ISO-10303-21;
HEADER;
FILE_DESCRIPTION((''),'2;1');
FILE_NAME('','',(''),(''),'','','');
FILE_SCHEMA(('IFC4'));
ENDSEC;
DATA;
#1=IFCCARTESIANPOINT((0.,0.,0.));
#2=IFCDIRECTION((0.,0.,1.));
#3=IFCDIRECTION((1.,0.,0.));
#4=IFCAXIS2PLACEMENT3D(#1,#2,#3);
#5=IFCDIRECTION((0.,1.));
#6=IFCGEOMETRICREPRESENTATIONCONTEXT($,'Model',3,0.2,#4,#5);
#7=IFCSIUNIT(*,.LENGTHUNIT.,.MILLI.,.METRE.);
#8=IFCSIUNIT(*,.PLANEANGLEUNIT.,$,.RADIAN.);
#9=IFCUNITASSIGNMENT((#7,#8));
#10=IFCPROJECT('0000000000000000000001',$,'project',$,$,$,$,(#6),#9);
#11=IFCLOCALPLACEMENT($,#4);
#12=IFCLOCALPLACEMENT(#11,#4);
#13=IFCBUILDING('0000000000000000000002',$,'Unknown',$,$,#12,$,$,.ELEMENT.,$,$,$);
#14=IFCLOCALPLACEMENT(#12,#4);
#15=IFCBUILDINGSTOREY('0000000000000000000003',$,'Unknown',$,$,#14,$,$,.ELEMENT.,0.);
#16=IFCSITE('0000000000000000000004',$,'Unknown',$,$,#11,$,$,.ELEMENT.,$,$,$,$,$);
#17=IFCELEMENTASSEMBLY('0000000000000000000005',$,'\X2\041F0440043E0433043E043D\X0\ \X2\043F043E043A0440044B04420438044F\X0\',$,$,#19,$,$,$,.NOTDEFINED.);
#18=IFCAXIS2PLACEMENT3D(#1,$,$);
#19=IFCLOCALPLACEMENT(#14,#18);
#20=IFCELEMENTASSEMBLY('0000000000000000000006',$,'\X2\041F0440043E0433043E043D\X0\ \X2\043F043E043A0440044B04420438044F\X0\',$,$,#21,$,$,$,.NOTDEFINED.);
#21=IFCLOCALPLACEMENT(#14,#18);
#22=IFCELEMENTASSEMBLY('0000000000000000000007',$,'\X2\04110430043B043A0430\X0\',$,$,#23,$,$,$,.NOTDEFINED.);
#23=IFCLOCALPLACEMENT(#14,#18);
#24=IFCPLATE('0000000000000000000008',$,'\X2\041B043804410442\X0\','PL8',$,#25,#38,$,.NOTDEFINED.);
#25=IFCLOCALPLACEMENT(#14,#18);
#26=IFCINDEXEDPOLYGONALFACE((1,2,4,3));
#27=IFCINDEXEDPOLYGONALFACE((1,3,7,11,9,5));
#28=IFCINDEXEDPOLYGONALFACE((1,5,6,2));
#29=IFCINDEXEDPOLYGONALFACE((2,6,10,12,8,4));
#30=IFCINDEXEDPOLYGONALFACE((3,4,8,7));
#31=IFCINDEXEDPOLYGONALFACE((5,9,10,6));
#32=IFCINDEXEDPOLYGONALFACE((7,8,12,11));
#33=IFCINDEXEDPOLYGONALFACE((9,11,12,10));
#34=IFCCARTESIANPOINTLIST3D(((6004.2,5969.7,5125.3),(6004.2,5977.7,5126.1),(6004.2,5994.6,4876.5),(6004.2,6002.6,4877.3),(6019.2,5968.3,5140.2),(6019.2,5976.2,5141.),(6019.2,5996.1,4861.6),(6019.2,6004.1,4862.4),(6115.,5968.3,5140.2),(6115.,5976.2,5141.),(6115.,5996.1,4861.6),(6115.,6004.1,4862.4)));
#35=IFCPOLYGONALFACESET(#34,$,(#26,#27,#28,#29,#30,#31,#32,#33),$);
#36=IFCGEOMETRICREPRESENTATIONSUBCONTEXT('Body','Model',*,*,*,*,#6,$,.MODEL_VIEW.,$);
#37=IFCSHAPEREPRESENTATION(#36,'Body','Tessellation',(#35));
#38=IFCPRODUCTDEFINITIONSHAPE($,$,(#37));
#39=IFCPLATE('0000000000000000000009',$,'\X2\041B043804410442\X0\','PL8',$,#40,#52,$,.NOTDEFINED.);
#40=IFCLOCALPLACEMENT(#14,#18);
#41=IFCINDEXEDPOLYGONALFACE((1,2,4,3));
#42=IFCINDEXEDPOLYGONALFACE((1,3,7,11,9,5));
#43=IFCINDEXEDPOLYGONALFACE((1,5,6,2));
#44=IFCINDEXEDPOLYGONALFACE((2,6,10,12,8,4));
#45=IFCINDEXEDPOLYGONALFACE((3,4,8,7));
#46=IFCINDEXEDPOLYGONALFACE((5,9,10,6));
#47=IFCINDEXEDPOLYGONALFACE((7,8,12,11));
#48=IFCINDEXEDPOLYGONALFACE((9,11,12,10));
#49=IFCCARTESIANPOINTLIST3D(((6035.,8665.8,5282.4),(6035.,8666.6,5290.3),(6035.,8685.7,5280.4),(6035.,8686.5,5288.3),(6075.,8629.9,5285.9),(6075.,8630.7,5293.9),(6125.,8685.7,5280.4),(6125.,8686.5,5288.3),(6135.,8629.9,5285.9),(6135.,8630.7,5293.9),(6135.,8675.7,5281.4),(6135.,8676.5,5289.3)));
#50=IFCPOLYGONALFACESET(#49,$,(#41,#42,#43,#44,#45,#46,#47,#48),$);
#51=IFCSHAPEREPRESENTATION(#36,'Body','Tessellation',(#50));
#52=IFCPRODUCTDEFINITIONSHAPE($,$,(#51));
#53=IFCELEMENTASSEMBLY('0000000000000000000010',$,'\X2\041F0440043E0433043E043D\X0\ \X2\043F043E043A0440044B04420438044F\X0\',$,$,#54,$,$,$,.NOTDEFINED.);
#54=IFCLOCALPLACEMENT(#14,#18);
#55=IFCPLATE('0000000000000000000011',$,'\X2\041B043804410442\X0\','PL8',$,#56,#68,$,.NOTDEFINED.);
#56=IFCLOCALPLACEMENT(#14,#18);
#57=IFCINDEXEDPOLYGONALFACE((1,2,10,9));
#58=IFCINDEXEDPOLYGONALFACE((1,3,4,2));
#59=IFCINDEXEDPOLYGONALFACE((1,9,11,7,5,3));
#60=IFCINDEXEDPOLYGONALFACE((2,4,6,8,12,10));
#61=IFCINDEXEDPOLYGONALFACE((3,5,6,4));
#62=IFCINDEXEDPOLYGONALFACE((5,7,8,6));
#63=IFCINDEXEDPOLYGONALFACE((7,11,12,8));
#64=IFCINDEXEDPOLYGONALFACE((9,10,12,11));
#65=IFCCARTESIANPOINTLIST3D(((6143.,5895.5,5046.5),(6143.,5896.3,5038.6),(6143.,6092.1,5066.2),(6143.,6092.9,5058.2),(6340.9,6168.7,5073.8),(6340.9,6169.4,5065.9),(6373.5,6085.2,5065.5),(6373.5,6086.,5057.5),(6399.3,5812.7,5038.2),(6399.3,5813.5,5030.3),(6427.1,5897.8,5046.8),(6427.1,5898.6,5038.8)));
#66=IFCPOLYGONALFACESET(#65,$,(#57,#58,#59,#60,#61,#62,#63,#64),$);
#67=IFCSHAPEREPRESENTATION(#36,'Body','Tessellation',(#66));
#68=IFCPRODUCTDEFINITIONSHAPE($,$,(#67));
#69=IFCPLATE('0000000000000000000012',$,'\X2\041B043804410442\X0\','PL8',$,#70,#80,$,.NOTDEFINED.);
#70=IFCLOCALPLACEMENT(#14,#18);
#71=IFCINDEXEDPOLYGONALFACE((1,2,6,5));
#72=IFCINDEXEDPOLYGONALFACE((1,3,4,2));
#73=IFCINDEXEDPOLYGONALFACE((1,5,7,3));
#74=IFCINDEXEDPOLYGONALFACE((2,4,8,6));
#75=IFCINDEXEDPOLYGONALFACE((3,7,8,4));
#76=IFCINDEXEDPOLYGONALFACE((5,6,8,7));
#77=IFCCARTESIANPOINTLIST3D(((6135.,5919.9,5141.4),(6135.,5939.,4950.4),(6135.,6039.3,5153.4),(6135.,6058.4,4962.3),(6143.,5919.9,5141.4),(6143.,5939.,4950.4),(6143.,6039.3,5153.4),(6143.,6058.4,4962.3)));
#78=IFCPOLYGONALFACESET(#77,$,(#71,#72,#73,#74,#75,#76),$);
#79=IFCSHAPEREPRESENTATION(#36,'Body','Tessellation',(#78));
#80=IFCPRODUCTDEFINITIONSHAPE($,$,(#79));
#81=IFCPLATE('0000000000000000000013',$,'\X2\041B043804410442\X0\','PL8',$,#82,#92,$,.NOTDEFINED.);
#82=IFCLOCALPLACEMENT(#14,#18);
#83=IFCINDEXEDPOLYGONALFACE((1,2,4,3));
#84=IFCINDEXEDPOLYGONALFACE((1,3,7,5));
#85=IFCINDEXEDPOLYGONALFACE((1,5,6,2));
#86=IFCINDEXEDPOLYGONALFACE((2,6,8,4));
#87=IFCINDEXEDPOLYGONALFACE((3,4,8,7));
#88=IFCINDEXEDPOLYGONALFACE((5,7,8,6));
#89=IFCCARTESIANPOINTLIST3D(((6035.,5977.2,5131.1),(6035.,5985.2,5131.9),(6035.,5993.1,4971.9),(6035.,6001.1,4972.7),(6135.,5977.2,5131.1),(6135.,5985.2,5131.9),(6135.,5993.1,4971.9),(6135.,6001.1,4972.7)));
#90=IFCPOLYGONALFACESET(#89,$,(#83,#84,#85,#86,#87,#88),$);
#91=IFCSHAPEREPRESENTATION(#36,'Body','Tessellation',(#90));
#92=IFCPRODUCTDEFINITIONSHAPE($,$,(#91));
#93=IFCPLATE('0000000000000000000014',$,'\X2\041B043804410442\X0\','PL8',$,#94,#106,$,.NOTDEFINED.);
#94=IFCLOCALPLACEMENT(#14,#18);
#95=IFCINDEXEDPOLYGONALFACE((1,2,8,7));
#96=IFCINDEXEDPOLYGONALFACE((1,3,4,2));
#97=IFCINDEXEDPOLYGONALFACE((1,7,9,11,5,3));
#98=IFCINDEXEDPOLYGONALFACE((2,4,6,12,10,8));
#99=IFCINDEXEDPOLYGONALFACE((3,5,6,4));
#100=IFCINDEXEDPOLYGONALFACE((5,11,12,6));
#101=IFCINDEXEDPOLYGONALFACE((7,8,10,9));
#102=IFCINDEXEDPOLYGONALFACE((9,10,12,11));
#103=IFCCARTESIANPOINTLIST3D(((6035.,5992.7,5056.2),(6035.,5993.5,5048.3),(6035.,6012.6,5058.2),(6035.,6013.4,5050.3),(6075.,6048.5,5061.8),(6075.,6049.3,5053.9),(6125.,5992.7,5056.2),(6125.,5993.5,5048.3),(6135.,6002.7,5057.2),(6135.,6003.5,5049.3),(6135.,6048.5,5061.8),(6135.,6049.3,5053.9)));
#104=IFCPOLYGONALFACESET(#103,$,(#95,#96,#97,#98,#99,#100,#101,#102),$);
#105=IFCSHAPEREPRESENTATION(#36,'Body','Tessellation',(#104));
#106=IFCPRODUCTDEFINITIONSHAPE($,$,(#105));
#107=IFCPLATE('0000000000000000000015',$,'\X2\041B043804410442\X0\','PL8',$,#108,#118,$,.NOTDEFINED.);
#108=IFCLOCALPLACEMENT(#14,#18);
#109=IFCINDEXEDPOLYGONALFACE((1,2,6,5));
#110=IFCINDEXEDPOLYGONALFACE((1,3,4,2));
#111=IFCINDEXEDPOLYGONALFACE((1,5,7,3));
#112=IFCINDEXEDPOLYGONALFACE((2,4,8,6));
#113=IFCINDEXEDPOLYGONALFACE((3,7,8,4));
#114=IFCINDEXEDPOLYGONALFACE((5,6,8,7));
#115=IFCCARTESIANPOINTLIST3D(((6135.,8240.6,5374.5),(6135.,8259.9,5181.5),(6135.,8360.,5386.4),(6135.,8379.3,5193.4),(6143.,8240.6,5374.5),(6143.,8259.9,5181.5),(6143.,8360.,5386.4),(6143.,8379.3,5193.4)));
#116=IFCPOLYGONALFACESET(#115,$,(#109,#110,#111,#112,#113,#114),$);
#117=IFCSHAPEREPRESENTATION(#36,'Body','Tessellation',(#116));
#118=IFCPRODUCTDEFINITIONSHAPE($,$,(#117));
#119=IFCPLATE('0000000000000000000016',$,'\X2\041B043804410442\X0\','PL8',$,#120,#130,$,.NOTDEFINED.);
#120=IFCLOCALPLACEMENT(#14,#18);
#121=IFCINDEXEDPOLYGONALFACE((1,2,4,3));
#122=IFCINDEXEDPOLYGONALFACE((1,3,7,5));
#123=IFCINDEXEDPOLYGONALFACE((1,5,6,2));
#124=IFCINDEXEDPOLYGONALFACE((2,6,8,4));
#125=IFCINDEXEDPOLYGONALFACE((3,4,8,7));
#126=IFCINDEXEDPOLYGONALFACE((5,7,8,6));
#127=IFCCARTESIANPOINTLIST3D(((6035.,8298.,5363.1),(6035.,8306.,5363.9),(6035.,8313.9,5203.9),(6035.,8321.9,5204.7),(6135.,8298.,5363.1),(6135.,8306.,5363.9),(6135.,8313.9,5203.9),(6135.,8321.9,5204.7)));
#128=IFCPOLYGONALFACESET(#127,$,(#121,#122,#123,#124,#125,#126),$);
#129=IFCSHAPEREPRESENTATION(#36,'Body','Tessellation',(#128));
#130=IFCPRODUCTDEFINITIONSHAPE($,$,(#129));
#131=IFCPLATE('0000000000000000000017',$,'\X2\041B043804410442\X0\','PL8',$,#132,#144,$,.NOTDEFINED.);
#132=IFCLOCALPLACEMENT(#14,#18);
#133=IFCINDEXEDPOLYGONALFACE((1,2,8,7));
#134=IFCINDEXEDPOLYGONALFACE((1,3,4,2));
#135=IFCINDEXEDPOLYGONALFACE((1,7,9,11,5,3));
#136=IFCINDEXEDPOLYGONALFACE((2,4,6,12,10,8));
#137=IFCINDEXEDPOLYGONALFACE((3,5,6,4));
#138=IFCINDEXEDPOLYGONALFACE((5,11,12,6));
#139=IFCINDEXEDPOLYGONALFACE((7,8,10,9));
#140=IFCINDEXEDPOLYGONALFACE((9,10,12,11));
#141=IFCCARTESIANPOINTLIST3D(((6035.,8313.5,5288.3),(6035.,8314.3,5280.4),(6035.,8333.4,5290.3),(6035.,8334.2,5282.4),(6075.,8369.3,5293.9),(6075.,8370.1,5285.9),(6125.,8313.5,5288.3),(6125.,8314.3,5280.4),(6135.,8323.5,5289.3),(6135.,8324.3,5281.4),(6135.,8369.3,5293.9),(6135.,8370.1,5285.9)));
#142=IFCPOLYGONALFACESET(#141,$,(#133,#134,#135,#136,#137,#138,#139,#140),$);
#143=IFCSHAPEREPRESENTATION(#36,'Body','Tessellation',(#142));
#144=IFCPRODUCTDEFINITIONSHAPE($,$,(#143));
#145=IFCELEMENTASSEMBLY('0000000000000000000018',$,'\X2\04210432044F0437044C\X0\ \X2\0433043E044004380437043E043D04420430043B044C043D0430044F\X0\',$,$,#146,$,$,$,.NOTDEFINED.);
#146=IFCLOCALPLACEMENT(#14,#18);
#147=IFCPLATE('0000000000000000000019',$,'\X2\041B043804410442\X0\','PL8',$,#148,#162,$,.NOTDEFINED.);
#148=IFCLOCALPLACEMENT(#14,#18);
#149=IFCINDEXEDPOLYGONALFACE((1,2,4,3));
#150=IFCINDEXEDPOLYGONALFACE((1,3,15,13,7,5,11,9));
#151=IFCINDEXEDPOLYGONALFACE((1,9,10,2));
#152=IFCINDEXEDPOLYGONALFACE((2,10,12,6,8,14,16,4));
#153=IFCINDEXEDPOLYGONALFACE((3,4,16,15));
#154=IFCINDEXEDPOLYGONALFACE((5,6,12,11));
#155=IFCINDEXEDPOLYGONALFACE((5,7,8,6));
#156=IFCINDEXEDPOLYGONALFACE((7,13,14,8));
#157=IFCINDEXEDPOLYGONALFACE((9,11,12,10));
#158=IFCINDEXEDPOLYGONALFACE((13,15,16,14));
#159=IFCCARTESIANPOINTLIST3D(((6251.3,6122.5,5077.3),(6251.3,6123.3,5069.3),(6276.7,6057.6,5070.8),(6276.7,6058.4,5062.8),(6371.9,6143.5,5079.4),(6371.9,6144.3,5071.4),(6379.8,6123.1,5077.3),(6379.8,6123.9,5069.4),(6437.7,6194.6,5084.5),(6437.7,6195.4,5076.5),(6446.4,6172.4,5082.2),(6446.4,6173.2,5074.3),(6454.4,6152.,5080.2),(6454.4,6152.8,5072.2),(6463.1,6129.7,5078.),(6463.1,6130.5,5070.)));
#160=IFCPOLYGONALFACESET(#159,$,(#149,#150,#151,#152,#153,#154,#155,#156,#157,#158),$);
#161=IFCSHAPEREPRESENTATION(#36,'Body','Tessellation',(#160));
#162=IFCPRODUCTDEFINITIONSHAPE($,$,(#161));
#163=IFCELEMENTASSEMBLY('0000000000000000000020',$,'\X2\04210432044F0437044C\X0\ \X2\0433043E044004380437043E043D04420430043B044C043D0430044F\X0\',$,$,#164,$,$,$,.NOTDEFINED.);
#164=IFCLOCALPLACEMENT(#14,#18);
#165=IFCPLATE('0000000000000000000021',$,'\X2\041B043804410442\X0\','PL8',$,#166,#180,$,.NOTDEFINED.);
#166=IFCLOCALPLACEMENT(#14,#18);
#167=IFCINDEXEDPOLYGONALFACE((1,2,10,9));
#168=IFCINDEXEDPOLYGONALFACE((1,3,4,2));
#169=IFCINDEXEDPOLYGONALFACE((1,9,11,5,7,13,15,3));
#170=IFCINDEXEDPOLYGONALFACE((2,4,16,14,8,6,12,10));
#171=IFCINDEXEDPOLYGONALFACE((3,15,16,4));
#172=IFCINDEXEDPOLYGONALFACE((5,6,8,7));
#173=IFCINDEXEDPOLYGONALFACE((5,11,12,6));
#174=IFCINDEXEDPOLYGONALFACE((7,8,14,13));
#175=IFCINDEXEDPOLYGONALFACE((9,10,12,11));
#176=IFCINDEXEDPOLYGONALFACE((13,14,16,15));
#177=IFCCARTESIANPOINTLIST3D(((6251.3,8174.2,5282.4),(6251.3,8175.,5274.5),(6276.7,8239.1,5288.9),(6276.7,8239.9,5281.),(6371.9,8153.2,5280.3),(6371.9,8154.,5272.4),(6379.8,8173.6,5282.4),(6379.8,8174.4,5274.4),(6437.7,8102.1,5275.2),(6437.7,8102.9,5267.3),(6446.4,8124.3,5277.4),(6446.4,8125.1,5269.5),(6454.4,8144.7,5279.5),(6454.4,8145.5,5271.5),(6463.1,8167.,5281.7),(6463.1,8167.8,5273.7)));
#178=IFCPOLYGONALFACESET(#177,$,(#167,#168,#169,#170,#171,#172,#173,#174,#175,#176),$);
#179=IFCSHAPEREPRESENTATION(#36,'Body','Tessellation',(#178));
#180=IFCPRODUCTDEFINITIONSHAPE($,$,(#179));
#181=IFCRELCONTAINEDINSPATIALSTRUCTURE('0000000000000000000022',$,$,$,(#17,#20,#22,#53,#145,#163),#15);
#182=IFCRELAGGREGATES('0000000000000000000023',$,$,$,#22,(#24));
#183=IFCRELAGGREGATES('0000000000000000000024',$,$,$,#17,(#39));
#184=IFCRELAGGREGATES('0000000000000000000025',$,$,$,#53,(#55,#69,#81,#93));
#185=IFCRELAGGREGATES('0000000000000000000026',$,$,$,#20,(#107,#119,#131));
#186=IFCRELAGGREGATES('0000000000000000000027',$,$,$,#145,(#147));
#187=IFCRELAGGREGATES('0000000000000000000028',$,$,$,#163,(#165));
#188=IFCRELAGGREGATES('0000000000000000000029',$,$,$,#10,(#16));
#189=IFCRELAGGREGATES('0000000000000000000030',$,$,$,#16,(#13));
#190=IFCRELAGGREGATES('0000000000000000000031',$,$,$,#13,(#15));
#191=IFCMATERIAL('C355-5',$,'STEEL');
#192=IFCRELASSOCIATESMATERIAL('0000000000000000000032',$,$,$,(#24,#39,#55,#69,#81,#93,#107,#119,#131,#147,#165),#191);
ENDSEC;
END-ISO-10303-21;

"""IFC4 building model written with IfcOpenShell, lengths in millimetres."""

from ifc_helpers import new_model, si_unit, direction, frame, origin_with_axes, place, context, subcontext, project, spatial, line, indexed_curve, outline, extrude, material, element, aggregate, save


model = new_model("IFC4")

# Units and contexts
model_context = context("Model", 3, precision=0.2, world=origin_with_axes(), true_north=direction((0.0, 1.0)))
body_context = subcontext(model_context, "Body", "Model", "MODEL_VIEW")
ifc_project = project(units=[si_unit("LENGTHUNIT", "METRE", prefix="MILLI"), si_unit("PLANEANGLEUNIT", "RADIAN")], contexts=[model_context])

# Site, building, storey
site_placement = place(None, origin_with_axes())
site = spatial("IfcSite", under=ifc_project, at=site_placement, Name="Unknown", CompositionType="ELEMENT")
building_placement = place(site_placement, origin_with_axes())
building = spatial("IfcBuilding", under=site, at=building_placement, Name="Unknown", CompositionType="ELEMENT")
storey_placement = place(building_placement, origin_with_axes())
storey = spatial("IfcBuildingStorey", under=building, at=storey_placement, Name="Unknown", CompositionType="ELEMENT", Elevation=0.0)

# Element assemblies
assembly_1_placement = place(storey_placement, frame((12000.0, 8690.0, 5283.9), z_axis=(0.0, -0.995037, 0.099504), x_axis=(-1.0, 0.0, 0.0)))
assembly_1 = element("IfcElementAssembly", 1, at=assembly_1_placement, inside=storey, Name="Прогон покрытия", PredefinedType="NOTDEFINED")
ifc_material_1 = material(Name="C355-5", Category="STEEL")
assembly_2_placement = place(storey_placement, frame((6000.0, 8310.0, 5283.9), z_axis=(0.0, 0.995037, 0.099504), x_axis=(1.0, 0.0, 0.0)))
assembly_2 = element("IfcElementAssembly", 2, at=assembly_2_placement, inside=storey, Name="Прогон покрытия", PredefinedType="NOTDEFINED")

# Element assembly, plate
assembly_3_placement = place(storey_placement, frame((6000.0, 346.0, 4437.3), z_axis=(1.0, 0.0, 0.0), x_axis=(0.0, 0.995037, 0.099504)))
assembly_3 = element("IfcElementAssembly", 3, at=assembly_3_placement, inside=storey, Name="Балка", PredefinedType="NOTDEFINED")
plate_1_placement = place(assembly_3_placement, frame((5668.3, 140.0, 115.0), z_axis=(-1.0, 0.0, 0.0), x_axis=(0.0, 0.0, -1.0)))
plate_1 = element("IfcPlate", 4, at=plate_1_placement, material=ifc_material_1, Name="Лист", Description="PL8", PredefinedType="NOTDEFINED", context=body_context, shape_type="SolidModel", body=[
    extrude(outline(indexed_curve([(0.0, 0.0), (95.8, 0.0), (110.8, 15.0), (110.8, 265.0), (95.8, 280.0), (0.0, 280.0)], segments=[line(1, 2, 3, 4, 5, 6, 1)])), frame((0.0, 0.0, 4.0), z_axis=(0.0, 0.0, 1.0), x_axis=(1.0, 0.0, 0.0)), (0.0, 0.0, -1.0), 8.0),
])
aggregate(assembly_3, [plate_1])

# Plate
plate_2_placement = place(assembly_1_placement, frame((5965.0, 0.0, 60.0), z_axis=(0.0, 1.0, 0.0), x_axis=(0.0, 0.0, -1.0)))
plate_2 = element("IfcPlate", 5, at=plate_2_placement, material=ifc_material_1, Name="Лист", Description="PL8", PredefinedType="NOTDEFINED", context=body_context, shape_type="SolidModel", body=[
    extrude(outline(indexed_curve([(0.0, 40.0), (36.0, 0.0), (56.0, 0.0), (56.0, 90.0), (46.0, 100.0), (0.0, 100.0)], segments=[line(1, 2, 3, 4, 5, 6, 1)])), frame((0.0, 0.0, 4.0), z_axis=(0.0, 0.0, 1.0), x_axis=(1.0, 0.0, 0.0)), (0.0, 0.0, -1.0), 8.0),
])
aggregate(assembly_1, [plate_2])

# Element assembly, plates
assembly_4_placement = place(storey_placement, frame((6000.0, 5989.2, 5051.9), z_axis=(0.0, 0.995037, 0.099504), x_axis=(1.0, 0.0, 0.0)))
assembly_4 = element("IfcElementAssembly", 6, at=assembly_4_placement, inside=storey, Name="Прогон покрытия", PredefinedType="NOTDEFINED")
plate_3_placement = place(assembly_4_placement, frame((373.5, 0.0, 96.9), z_axis=(0.0, -1.0, 0.0), x_axis=(-0.362317, 0.0, 0.932055)))
plate_3 = element("IfcPlate", 7, at=plate_3_placement, material=ifc_material_1, Name="Лист", Description="PL8", PredefinedType="NOTDEFINED", context=body_context, shape_type="SolidModel", body=[
    extrude(outline(indexed_curve([(0.0, 0.0), (90.0, 0.0), (90.0, 212.3), (-94.2, 283.9), (-264.6, 75.2), (-194.9, 18.3)], segments=[line(1, 2, 3, 4, 5, 6, 1)])), frame((0.0, 0.0, 4.0), z_axis=(0.0, 0.0, 1.0), x_axis=(1.0, 0.0, 0.0)), (0.0, 0.0, -1.0), 8.0),
])
plate_4_placement = place(assembly_4_placement, frame((139.0, -96.0, -60.0), z_axis=(-1.0, 0.0, 0.0), x_axis=(0.0, 0.0, 1.0)))
plate_4 = element("IfcPlate", 8, at=plate_4_placement, material=ifc_material_1, Name="Лист", Description="PL8", PredefinedType="NOTDEFINED", context=body_context, shape_type="SolidModel", body=[
    extrude(outline(indexed_curve([(0.0, 0.0), (120.0, 0.0), (120.0, 192.0), (0.0, 192.0)], segments=[line(1, 2, 3, 4, 1)])), frame((0.0, 0.0, 4.0), z_axis=(0.0, 0.0, 1.0), x_axis=(1.0, 0.0, 0.0)), (0.0, 0.0, -1.0), 8.0),
])
plate_5_placement = place(assembly_4_placement, frame((35.0, -80.0, 0.0), z_axis=(0.0, 0.0, -1.0), x_axis=(0.0, 1.0, 0.0)))
plate_5 = element("IfcPlate", 9, at=plate_5_placement, material=ifc_material_1, Name="Лист", Description="PL8", PredefinedType="NOTDEFINED", context=body_context, shape_type="SolidModel", body=[
    extrude(outline(indexed_curve([(0.0, 0.0), (160.0, 0.0), (160.0, 100.0), (0.0, 100.0)], segments=[line(1, 2, 3, 4, 1)])), frame((0.0, 0.0, 4.0), z_axis=(0.0, 0.0, 1.0), x_axis=(1.0, 0.0, 0.0)), (0.0, 0.0, -1.0), 8.0),
])
plate_6_placement = place(assembly_4_placement, frame((35.0, 0.0, 60.0), z_axis=(0.0, -1.0, 0.0), x_axis=(0.0, 0.0, -1.0)))
plate_6 = element("IfcPlate", 10, at=plate_6_placement, material=ifc_material_1, Name="Лист", Description="PL8", PredefinedType="NOTDEFINED", context=body_context, shape_type="SolidModel", body=[
    extrude(outline(indexed_curve([(0.0, 40.0), (36.0, 0.0), (56.0, 0.0), (56.0, 90.0), (46.0, 100.0), (0.0, 100.0)], segments=[line(1, 2, 3, 4, 5, 6, 1)])), frame((0.0, 0.0, 4.0), z_axis=(0.0, 0.0, 1.0), x_axis=(1.0, 0.0, 0.0)), (0.0, 0.0, -1.0), 8.0),
])
aggregate(assembly_4, [plate_3, plate_4, plate_5, plate_6])

# Plates
plate_7_placement = place(assembly_2_placement, frame((139.0, -97.0, -60.0), z_axis=(-1.0, 0.0, 0.0), x_axis=(0.0, 0.0, 1.0)))
plate_7 = element("IfcPlate", 11, at=plate_7_placement, material=ifc_material_1, Name="Лист", Description="PL8", PredefinedType="NOTDEFINED", context=body_context, shape_type="SolidModel", body=[
    extrude(outline(indexed_curve([(0.0, 0.0), (120.0, 0.0), (120.0, 194.0), (0.0, 194.0)], segments=[line(1, 2, 3, 4, 1)])), frame((0.0, 0.0, 4.0), z_axis=(0.0, 0.0, 1.0), x_axis=(1.0, 0.0, 0.0)), (0.0, 0.0, -1.0), 8.0),
])
plate_8_placement = place(assembly_2_placement, frame((35.0, -80.0, 0.0), z_axis=(0.0, 0.0, -1.0), x_axis=(0.0, 1.0, 0.0)))
plate_8 = element("IfcPlate", 12, at=plate_8_placement, material=ifc_material_1, Name="Лист", Description="PL8", PredefinedType="NOTDEFINED", context=body_context, shape_type="SolidModel", body=[
    extrude(outline(indexed_curve([(0.0, 0.0), (160.0, 0.0), (160.0, 100.0), (0.0, 100.0)], segments=[line(1, 2, 3, 4, 1)])), frame((0.0, 0.0, 4.0), z_axis=(0.0, 0.0, 1.0), x_axis=(1.0, 0.0, 0.0)), (0.0, 0.0, -1.0), 8.0),
])
plate_9_placement = place(assembly_2_placement, frame((35.0, 0.0, 60.0), z_axis=(0.0, -1.0, 0.0), x_axis=(0.0, 0.0, -1.0)))
plate_9 = element("IfcPlate", 13, at=plate_9_placement, material=ifc_material_1, Name="Лист", Description="PL8", PredefinedType="NOTDEFINED", context=body_context, shape_type="SolidModel", body=[
    extrude(outline(indexed_curve([(0.0, 40.0), (36.0, 0.0), (56.0, 0.0), (56.0, 90.0), (46.0, 100.0), (0.0, 100.0)], segments=[line(1, 2, 3, 4, 5, 6, 1)])), frame((0.0, 0.0, 4.0), z_axis=(0.0, 0.0, 1.0), x_axis=(1.0, 0.0, 0.0)), (0.0, 0.0, -1.0), 8.0),
])
aggregate(assembly_2, [plate_7, plate_8, plate_9])

# Element assemblies, plates
assembly_5_placement = place(storey_placement, frame((6000.0, 5988.4, 5059.8), z_axis=(0.362317, -0.927429, -0.092743), x_axis=(0.932055, 0.360519, 0.036052)))
assembly_5 = element("IfcElementAssembly", 14, at=assembly_5_placement, inside=storey, Name="Связь горизонтальная", PredefinedType="NOTDEFINED")
plate_10_placement = place(assembly_5_placement, frame((483.2, 0.0, 35.0), z_axis=(0.0, -1.0, 0.0), x_axis=(-1.0, 0.0, 0.0)))
plate_10 = element("IfcPlate", 15, at=plate_10_placement, material=ifc_material_1, Name="Лист", Description="PL8", PredefinedType="NOTDEFINED", context=body_context, shape_type="SolidModel", body=[
    extrude(outline(indexed_curve([(0.0, 0.0), (200.0, 0.0), (200.0, 70.0), (0.0, 70.0), (0.0, 46.0), (80.0, 46.0), (80.0, 24.0), (0.0, 24.0)], segments=[line(1, 2, 3, 4, 5, 6, 7, 8, 1)])), frame((0.0, 0.0, 4.0), z_axis=(0.0, 0.0, 1.0), x_axis=(1.0, 0.0, 0.0)), (0.0, 0.0, -1.0), 8.0),
])
aggregate(assembly_5, [plate_10])
assembly_6_placement = place(storey_placement, frame((6000.0, 8309.2, 5291.9), z_axis=(-0.362317, -0.927429, -0.092743), x_axis=(0.932055, -0.360519, -0.036052)))
assembly_6 = element("IfcElementAssembly", 16, at=assembly_6_placement, inside=storey, Name="Связь горизонтальная", PredefinedType="NOTDEFINED")
plate_11_placement = place(assembly_6_placement, frame((483.2, 0.0, 35.0), z_axis=(0.0, -1.0, 0.0), x_axis=(-1.0, 0.0, 0.0)))
plate_11 = element("IfcPlate", 17, at=plate_11_placement, material=ifc_material_1, Name="Лист", Description="PL8", PredefinedType="NOTDEFINED", context=body_context, shape_type="SolidModel", body=[
    extrude(outline(indexed_curve([(0.0, 0.0), (200.0, 0.0), (200.0, 70.0), (0.0, 70.0), (0.0, 46.0), (80.0, 46.0), (80.0, 24.0), (0.0, 24.0)], segments=[line(1, 2, 3, 4, 5, 6, 7, 8, 1)])), frame((0.0, 0.0, 4.0), z_axis=(0.0, 0.0, 1.0), x_axis=(1.0, 0.0, 0.0)), (0.0, 0.0, -1.0), 8.0),
])
aggregate(assembly_6, [plate_11])

save(model, "model.ifc")
